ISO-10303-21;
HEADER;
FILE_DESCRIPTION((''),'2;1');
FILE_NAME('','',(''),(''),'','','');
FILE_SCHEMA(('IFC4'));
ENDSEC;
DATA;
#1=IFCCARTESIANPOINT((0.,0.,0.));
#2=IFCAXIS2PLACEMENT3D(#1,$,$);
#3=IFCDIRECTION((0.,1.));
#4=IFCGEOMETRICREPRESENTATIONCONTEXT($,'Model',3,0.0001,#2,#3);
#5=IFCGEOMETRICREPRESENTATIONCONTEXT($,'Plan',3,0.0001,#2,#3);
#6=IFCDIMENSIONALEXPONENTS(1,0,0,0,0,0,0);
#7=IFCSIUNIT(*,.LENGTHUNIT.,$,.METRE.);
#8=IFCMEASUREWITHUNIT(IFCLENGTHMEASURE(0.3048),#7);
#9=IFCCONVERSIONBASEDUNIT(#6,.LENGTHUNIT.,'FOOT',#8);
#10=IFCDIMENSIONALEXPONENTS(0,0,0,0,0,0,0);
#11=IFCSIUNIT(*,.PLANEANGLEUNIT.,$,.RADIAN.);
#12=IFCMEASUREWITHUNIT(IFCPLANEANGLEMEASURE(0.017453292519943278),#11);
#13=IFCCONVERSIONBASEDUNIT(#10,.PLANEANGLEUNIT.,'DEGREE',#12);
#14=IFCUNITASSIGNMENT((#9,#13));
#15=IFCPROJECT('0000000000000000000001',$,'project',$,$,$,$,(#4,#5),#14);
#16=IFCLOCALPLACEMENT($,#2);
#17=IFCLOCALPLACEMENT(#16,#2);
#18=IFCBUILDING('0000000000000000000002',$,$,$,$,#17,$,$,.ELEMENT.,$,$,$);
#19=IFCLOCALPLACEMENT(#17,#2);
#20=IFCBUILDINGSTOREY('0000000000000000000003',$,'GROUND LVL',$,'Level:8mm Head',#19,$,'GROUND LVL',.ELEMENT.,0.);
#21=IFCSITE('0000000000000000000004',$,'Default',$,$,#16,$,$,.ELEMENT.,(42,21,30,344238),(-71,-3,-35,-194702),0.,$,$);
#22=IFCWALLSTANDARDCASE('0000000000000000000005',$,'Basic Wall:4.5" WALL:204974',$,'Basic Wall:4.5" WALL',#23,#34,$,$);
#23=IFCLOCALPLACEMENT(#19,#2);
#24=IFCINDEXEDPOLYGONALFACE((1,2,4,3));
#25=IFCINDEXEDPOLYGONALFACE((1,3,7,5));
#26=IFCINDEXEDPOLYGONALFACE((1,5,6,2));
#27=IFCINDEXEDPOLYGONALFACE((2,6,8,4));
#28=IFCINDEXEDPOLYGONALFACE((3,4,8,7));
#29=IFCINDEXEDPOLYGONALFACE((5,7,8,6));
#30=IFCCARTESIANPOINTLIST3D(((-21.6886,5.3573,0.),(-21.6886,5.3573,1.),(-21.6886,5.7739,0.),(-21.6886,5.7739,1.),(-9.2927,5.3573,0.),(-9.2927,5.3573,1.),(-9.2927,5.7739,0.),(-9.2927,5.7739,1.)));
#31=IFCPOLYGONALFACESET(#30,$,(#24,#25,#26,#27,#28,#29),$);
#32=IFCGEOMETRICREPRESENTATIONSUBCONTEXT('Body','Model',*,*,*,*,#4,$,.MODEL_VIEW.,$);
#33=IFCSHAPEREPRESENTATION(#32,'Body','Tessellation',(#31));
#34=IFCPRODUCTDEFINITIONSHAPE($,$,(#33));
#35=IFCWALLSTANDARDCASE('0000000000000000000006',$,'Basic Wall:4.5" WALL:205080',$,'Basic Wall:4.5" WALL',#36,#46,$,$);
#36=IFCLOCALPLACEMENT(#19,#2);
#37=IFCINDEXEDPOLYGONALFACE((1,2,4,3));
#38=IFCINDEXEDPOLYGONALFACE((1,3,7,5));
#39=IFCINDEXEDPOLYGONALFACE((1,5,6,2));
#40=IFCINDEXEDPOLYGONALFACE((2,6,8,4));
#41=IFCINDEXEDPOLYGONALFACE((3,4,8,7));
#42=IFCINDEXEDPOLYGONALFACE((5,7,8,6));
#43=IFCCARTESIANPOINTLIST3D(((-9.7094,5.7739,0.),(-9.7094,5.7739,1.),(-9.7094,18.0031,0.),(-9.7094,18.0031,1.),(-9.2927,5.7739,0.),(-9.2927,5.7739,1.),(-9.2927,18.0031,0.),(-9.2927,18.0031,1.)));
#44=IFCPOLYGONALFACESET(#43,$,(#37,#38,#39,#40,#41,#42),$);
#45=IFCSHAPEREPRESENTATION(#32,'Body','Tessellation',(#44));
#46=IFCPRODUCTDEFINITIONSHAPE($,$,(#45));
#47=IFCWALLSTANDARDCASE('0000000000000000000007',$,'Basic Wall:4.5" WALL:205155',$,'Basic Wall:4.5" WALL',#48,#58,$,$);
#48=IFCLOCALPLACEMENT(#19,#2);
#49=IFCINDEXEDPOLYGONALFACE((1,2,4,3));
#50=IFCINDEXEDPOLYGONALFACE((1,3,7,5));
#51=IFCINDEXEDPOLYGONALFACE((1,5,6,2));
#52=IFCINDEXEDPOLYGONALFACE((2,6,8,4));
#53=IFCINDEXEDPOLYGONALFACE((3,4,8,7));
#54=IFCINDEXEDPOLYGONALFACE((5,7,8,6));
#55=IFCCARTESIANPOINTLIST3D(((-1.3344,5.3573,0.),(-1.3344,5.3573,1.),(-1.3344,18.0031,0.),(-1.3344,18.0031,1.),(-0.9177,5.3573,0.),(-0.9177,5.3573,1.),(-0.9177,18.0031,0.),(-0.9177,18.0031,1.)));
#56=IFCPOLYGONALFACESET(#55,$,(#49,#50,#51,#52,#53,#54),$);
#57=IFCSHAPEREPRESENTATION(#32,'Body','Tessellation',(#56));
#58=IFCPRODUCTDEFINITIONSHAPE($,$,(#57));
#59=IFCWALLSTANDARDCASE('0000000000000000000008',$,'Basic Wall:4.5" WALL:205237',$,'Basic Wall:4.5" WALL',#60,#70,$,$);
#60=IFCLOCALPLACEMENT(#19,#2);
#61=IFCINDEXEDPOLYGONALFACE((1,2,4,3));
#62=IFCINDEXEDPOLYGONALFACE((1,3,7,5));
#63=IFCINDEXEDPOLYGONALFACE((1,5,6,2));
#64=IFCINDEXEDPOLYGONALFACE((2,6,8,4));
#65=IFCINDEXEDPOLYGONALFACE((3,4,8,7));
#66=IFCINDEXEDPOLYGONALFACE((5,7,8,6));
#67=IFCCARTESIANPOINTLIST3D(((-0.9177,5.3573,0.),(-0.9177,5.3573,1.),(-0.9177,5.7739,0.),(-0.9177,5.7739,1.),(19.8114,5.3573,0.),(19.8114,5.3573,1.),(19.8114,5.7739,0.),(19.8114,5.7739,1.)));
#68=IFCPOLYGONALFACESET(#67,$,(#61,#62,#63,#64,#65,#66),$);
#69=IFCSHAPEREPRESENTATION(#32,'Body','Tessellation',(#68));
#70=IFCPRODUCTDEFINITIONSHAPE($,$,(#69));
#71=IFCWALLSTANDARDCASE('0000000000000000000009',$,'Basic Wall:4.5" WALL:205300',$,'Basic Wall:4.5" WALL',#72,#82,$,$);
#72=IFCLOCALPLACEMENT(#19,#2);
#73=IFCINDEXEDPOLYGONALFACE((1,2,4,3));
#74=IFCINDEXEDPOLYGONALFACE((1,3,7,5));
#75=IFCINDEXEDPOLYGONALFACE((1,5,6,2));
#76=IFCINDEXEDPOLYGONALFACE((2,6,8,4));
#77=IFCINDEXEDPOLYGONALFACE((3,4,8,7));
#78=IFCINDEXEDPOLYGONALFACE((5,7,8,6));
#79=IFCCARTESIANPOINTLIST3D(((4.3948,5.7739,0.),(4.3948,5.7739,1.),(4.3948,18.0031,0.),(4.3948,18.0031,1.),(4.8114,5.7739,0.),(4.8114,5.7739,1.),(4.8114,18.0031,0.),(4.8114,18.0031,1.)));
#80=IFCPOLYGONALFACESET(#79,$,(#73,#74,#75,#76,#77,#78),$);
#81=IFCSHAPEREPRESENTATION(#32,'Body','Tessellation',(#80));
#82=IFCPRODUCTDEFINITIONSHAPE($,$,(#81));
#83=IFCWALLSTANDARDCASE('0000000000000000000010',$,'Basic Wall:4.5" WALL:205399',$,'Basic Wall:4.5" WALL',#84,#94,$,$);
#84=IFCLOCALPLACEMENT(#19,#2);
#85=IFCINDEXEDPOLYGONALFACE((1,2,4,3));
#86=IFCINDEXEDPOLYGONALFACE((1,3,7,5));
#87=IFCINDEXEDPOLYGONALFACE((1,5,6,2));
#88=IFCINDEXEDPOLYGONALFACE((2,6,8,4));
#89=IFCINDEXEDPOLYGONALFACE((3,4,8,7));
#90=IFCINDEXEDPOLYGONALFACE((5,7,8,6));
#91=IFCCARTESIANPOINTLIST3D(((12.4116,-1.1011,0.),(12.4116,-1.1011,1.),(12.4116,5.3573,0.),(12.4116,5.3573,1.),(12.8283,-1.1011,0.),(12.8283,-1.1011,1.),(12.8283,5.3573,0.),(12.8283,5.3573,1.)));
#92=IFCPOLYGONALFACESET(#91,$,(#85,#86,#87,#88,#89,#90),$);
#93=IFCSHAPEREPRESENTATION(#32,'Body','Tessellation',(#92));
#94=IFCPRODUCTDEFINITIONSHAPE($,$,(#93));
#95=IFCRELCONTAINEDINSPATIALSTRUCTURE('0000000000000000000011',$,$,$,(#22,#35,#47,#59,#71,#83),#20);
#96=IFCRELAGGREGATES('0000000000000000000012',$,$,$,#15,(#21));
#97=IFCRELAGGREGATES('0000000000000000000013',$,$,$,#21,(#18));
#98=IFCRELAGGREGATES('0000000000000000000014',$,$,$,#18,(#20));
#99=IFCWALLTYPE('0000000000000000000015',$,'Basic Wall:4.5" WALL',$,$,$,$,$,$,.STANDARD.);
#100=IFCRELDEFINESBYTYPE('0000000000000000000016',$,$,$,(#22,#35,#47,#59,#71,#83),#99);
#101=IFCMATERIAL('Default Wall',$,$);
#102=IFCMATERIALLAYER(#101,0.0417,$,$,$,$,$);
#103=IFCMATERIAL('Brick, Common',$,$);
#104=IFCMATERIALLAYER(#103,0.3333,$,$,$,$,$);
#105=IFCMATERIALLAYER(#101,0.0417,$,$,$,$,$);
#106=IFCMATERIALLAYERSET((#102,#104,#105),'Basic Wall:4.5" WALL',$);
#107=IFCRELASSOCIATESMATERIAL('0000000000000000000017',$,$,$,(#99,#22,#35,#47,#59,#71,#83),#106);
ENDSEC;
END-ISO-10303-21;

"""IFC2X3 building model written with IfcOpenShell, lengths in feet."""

from ifc_helpers import new_model, entity, si_unit, converted_unit, direction, frame, frame_2d, origin, place, context, subcontext, project, spatial, polyline, rectangle, extrude, clip, bounded_halfspace, material, layer, layer_set, layer_usage, type_object, element, save


model = new_model("IFC2X3")

# Units and contexts
model_context = context("Model", 3, precision=0.0001, world=origin(), true_north=direction((0.0, 1.0)))
plan_context = context("Plan", 3, precision=0.0001, world=origin(), true_north=direction((0.0, 1.0)))
body_context = subcontext(model_context, "Body", "Model", "MODEL_VIEW")
ifc_project = project(units=[converted_unit("LENGTHUNIT", "FOOT", entity("IfcLengthMeasure", 0.3048), si_unit("LENGTHUNIT", "METRE"), dimensions=[1, 0, 0, 0, 0, 0, 0]), converted_unit("PLANEANGLEUNIT", "DEGREE", entity("IfcPlaneAngleMeasure", 0.017453292519943278), si_unit("PLANEANGLEUNIT", "RADIAN"), dimensions=[0, 0, 0, 0, 0, 0, 0])], contexts=[model_context, plan_context])

# Site, building, storey
site_placement = place(None, origin())
site = spatial("IfcSite", under=ifc_project, at=site_placement, Name="Default", CompositionType="ELEMENT", RefLatitude=(42, 21, 30, 344238), RefLongitude=(-71, -3, -35, -194702), RefElevation=0.0)
building_placement = place(site_placement, origin())
building = spatial("IfcBuilding", under=site, at=building_placement, CompositionType="ELEMENT")
storey_placement = place(building_placement, origin())
storey = spatial("IfcBuildingStorey", under=building, at=storey_placement, Name="GROUND LVL", ObjectType="Level:8mm Head", LongName="GROUND LVL", CompositionType="ELEMENT", Elevation=0.0)

# Walls
ifc_material_1 = material(Name="Default Wall")
ifc_material_2 = material(Name="Brick, Common")
ifc_layer_1 = layer(ifc_material_1, 0.0417)
ifc_layer_2 = layer(ifc_material_2, 0.3333)
ifc_layer_3 = layer(ifc_material_1, 0.0417)
ifc_layer_set_1 = layer_set([ifc_layer_1, ifc_layer_2, ifc_layer_3], Name="Basic Wall:4.5\" WALL")
wall_type_1 = type_object("IfcWallType", Name="Basic Wall:4.5\" WALL", PredefinedType="STANDARD", material=ifc_layer_set_1)
ifc_layer_usage_1 = layer_usage(ifc_layer_set_1, "AXIS2", "NEGATIVE", 0.2083)
wall_1_placement = place(storey_placement, frame((-21.6886, 5.5656, 0.0)))
element("IfcWallStandardCase", 1, at=wall_1_placement, inside=storey, type_object=wall_type_1, material=ifc_layer_usage_1, Name="Basic Wall:4.5\" WALL:204974", ObjectType="Basic Wall:4.5\" WALL", context=body_context, shape_type="Clipping", body=[
    clip(extrude(rectangle(XDim=12.3958, YDim=0.4167, at=frame_2d((6.1979, 0.0), x_axis=(-1.0, 0.0))), origin(), (0.0, 0.0, 1.0), 1.0), bounded_halfspace(frame((0.0, -0.2083, 1.0), z_axis=(0.0, 0.0, -1.0), x_axis=(0.0, -1.0, 0.0)), True, frame((0.0, -0.2083, 1.0)), polyline([(0.0, 0.0), (7.6042, 0.0), (8.0208, 0.0), (12.3958, 0.0), (12.3958, 0.4167), (11.9792, 0.4167), (0.0, 0.4167), (0.0, 0.0)]))),
])
ifc_layer_usage_2 = layer_usage(ifc_layer_set_1, "AXIS2", "NEGATIVE", 0.2083)
wall_2_placement = place(storey_placement, frame((-9.5011, 18.0031, 0.0), z_axis=(0.0, 0.0, 1.0), x_axis=(0.0, -1.0, 0.0)))
element("IfcWallStandardCase", 2, at=wall_2_placement, inside=storey, type_object=wall_type_1, material=ifc_layer_usage_2, Name="Basic Wall:4.5\" WALL:205080", ObjectType="Basic Wall:4.5\" WALL", context=body_context, shape_type="Clipping", body=[
    clip(extrude(rectangle(XDim=12.2292, YDim=0.4167, at=frame_2d((6.1146, 0.0), x_axis=(-1.0, 0.0))), origin(), (0.0, 0.0, 1.0), 1.0), bounded_halfspace(frame((0.0, -0.2083, 1.0), z_axis=(0.0, 0.0, -1.0), x_axis=(1.0, 0.0, 0.0)), True, frame((0.0, -0.2083, 1.0)), polyline([(0.0, 0.0), (12.2292, 0.0), (12.2292, 0.4167), (0.0, 0.4167), (0.0, 0.0)]))),
])
ifc_layer_usage_3 = layer_usage(ifc_layer_set_1, "AXIS2", "NEGATIVE", 0.2083)
wall_3_placement = place(storey_placement, frame((-1.1261, 18.0031, 0.0), z_axis=(0.0, 0.0, 1.0), x_axis=(0.0, -1.0, 0.0)))
element("IfcWallStandardCase", 3, at=wall_3_placement, inside=storey, type_object=wall_type_1, material=ifc_layer_usage_3, Name="Basic Wall:4.5\" WALL:205155", ObjectType="Basic Wall:4.5\" WALL", context=body_context, shape_type="Clipping", body=[
    clip(extrude(rectangle(XDim=12.6458, YDim=0.4167, at=frame_2d((6.3229, 0.0), x_axis=(-1.0, 0.0))), origin(), (0.0, 0.0, 1.0), 1.0), bounded_halfspace(frame((0.0, -0.2083, 1.0), z_axis=(0.0, 0.0, -1.0), x_axis=(1.0, 0.0, 0.0)), True, frame((0.0, -0.2083, 1.0)), polyline([(0.0, 0.0), (12.6458, 0.0), (12.6458, 0.4167), (12.2292, 0.4167), (0.0, 0.4167), (0.0, 0.0)]))),
])
ifc_layer_usage_4 = layer_usage(ifc_layer_set_1, "AXIS2", "NEGATIVE", 0.2083)
wall_4_placement = place(storey_placement, frame((-0.9177, 5.5656, 0.0)))
element("IfcWallStandardCase", 4, at=wall_4_placement, inside=storey, type_object=wall_type_1, material=ifc_layer_usage_4, Name="Basic Wall:4.5\" WALL:205237", ObjectType="Basic Wall:4.5\" WALL", context=body_context, shape_type="Clipping", body=[
    clip(extrude(rectangle(XDim=20.7292, YDim=0.4167, at=frame_2d((10.3646, 0.0), x_axis=(-1.0, 0.0))), origin(), (0.0, 0.0, 1.0), 1.0), bounded_halfspace(frame((0.0, -0.2083, 1.0), z_axis=(0.0, 0.0, -1.0), x_axis=(0.0, -1.0, 0.0)), True, frame((0.0, -0.2083, 1.0)), polyline([(0.0, 0.0), (13.3293, 0.0), (13.746, 0.0), (20.7292, 0.0), (20.7292, 0.4167), (5.7292, 0.4167), (5.3125, 0.4167), (0.0, 0.4167), (0.0, 0.0)]))),
])
ifc_layer_usage_5 = layer_usage(ifc_layer_set_1, "AXIS2", "NEGATIVE", 0.2083)
wall_5_placement = place(storey_placement, frame((4.6031, 5.7739, 0.0), z_axis=(0.0, 0.0, 1.0), x_axis=(0.0, 1.0, 0.0)))
element("IfcWallStandardCase", 5, at=wall_5_placement, inside=storey, type_object=wall_type_1, material=ifc_layer_usage_5, Name="Basic Wall:4.5\" WALL:205300", ObjectType="Basic Wall:4.5\" WALL", context=body_context, shape_type="Clipping", body=[
    clip(extrude(rectangle(XDim=12.2292, YDim=0.4167, at=frame_2d((6.1146, 0.0), x_axis=(-1.0, 0.0))), origin(), (0.0, 0.0, 1.0), 1.0), bounded_halfspace(frame((0.0, -0.2083, 1.0), z_axis=(0.0, 0.0, -1.0), x_axis=(-1.0, 0.0, 0.0)), True, frame((0.0, -0.2083, 1.0)), polyline([(0.0, 0.0), (12.2292, 0.0), (12.2292, 0.4167), (0.0, 0.4167), (0.0, 0.0)]))),
])
ifc_layer_usage_6 = layer_usage(ifc_layer_set_1, "AXIS2", "NEGATIVE", 0.2083)
wall_6_placement = place(storey_placement, frame((12.6199, 5.3573, 0.0), z_axis=(0.0, 0.0, 1.0), x_axis=(0.0, -1.0, 0.0)))
element("IfcWallStandardCase", 6, at=wall_6_placement, inside=storey, type_object=wall_type_1, material=ifc_layer_usage_6, Name="Basic Wall:4.5\" WALL:205399", ObjectType="Basic Wall:4.5\" WALL", context=body_context, shape_type="Clipping", body=[
    clip(extrude(rectangle(XDim=6.4583, YDim=0.4167, at=frame_2d((3.2292, 0.0), x_axis=(-1.0, 0.0))), origin(), (0.0, 0.0, 1.0), 1.0), bounded_halfspace(frame((0.0, -0.2083, 1.0), z_axis=(0.0, 0.0, -1.0), x_axis=(1.0, 0.0, 0.0)), True, frame((0.0, -0.2083, 1.0)), polyline([(0.0, 0.0), (6.4583, 0.0), (6.4583, 0.4167), (0.0, 0.4167), (0.0, 0.0)]))),
])

save(model, "model.ifc")
